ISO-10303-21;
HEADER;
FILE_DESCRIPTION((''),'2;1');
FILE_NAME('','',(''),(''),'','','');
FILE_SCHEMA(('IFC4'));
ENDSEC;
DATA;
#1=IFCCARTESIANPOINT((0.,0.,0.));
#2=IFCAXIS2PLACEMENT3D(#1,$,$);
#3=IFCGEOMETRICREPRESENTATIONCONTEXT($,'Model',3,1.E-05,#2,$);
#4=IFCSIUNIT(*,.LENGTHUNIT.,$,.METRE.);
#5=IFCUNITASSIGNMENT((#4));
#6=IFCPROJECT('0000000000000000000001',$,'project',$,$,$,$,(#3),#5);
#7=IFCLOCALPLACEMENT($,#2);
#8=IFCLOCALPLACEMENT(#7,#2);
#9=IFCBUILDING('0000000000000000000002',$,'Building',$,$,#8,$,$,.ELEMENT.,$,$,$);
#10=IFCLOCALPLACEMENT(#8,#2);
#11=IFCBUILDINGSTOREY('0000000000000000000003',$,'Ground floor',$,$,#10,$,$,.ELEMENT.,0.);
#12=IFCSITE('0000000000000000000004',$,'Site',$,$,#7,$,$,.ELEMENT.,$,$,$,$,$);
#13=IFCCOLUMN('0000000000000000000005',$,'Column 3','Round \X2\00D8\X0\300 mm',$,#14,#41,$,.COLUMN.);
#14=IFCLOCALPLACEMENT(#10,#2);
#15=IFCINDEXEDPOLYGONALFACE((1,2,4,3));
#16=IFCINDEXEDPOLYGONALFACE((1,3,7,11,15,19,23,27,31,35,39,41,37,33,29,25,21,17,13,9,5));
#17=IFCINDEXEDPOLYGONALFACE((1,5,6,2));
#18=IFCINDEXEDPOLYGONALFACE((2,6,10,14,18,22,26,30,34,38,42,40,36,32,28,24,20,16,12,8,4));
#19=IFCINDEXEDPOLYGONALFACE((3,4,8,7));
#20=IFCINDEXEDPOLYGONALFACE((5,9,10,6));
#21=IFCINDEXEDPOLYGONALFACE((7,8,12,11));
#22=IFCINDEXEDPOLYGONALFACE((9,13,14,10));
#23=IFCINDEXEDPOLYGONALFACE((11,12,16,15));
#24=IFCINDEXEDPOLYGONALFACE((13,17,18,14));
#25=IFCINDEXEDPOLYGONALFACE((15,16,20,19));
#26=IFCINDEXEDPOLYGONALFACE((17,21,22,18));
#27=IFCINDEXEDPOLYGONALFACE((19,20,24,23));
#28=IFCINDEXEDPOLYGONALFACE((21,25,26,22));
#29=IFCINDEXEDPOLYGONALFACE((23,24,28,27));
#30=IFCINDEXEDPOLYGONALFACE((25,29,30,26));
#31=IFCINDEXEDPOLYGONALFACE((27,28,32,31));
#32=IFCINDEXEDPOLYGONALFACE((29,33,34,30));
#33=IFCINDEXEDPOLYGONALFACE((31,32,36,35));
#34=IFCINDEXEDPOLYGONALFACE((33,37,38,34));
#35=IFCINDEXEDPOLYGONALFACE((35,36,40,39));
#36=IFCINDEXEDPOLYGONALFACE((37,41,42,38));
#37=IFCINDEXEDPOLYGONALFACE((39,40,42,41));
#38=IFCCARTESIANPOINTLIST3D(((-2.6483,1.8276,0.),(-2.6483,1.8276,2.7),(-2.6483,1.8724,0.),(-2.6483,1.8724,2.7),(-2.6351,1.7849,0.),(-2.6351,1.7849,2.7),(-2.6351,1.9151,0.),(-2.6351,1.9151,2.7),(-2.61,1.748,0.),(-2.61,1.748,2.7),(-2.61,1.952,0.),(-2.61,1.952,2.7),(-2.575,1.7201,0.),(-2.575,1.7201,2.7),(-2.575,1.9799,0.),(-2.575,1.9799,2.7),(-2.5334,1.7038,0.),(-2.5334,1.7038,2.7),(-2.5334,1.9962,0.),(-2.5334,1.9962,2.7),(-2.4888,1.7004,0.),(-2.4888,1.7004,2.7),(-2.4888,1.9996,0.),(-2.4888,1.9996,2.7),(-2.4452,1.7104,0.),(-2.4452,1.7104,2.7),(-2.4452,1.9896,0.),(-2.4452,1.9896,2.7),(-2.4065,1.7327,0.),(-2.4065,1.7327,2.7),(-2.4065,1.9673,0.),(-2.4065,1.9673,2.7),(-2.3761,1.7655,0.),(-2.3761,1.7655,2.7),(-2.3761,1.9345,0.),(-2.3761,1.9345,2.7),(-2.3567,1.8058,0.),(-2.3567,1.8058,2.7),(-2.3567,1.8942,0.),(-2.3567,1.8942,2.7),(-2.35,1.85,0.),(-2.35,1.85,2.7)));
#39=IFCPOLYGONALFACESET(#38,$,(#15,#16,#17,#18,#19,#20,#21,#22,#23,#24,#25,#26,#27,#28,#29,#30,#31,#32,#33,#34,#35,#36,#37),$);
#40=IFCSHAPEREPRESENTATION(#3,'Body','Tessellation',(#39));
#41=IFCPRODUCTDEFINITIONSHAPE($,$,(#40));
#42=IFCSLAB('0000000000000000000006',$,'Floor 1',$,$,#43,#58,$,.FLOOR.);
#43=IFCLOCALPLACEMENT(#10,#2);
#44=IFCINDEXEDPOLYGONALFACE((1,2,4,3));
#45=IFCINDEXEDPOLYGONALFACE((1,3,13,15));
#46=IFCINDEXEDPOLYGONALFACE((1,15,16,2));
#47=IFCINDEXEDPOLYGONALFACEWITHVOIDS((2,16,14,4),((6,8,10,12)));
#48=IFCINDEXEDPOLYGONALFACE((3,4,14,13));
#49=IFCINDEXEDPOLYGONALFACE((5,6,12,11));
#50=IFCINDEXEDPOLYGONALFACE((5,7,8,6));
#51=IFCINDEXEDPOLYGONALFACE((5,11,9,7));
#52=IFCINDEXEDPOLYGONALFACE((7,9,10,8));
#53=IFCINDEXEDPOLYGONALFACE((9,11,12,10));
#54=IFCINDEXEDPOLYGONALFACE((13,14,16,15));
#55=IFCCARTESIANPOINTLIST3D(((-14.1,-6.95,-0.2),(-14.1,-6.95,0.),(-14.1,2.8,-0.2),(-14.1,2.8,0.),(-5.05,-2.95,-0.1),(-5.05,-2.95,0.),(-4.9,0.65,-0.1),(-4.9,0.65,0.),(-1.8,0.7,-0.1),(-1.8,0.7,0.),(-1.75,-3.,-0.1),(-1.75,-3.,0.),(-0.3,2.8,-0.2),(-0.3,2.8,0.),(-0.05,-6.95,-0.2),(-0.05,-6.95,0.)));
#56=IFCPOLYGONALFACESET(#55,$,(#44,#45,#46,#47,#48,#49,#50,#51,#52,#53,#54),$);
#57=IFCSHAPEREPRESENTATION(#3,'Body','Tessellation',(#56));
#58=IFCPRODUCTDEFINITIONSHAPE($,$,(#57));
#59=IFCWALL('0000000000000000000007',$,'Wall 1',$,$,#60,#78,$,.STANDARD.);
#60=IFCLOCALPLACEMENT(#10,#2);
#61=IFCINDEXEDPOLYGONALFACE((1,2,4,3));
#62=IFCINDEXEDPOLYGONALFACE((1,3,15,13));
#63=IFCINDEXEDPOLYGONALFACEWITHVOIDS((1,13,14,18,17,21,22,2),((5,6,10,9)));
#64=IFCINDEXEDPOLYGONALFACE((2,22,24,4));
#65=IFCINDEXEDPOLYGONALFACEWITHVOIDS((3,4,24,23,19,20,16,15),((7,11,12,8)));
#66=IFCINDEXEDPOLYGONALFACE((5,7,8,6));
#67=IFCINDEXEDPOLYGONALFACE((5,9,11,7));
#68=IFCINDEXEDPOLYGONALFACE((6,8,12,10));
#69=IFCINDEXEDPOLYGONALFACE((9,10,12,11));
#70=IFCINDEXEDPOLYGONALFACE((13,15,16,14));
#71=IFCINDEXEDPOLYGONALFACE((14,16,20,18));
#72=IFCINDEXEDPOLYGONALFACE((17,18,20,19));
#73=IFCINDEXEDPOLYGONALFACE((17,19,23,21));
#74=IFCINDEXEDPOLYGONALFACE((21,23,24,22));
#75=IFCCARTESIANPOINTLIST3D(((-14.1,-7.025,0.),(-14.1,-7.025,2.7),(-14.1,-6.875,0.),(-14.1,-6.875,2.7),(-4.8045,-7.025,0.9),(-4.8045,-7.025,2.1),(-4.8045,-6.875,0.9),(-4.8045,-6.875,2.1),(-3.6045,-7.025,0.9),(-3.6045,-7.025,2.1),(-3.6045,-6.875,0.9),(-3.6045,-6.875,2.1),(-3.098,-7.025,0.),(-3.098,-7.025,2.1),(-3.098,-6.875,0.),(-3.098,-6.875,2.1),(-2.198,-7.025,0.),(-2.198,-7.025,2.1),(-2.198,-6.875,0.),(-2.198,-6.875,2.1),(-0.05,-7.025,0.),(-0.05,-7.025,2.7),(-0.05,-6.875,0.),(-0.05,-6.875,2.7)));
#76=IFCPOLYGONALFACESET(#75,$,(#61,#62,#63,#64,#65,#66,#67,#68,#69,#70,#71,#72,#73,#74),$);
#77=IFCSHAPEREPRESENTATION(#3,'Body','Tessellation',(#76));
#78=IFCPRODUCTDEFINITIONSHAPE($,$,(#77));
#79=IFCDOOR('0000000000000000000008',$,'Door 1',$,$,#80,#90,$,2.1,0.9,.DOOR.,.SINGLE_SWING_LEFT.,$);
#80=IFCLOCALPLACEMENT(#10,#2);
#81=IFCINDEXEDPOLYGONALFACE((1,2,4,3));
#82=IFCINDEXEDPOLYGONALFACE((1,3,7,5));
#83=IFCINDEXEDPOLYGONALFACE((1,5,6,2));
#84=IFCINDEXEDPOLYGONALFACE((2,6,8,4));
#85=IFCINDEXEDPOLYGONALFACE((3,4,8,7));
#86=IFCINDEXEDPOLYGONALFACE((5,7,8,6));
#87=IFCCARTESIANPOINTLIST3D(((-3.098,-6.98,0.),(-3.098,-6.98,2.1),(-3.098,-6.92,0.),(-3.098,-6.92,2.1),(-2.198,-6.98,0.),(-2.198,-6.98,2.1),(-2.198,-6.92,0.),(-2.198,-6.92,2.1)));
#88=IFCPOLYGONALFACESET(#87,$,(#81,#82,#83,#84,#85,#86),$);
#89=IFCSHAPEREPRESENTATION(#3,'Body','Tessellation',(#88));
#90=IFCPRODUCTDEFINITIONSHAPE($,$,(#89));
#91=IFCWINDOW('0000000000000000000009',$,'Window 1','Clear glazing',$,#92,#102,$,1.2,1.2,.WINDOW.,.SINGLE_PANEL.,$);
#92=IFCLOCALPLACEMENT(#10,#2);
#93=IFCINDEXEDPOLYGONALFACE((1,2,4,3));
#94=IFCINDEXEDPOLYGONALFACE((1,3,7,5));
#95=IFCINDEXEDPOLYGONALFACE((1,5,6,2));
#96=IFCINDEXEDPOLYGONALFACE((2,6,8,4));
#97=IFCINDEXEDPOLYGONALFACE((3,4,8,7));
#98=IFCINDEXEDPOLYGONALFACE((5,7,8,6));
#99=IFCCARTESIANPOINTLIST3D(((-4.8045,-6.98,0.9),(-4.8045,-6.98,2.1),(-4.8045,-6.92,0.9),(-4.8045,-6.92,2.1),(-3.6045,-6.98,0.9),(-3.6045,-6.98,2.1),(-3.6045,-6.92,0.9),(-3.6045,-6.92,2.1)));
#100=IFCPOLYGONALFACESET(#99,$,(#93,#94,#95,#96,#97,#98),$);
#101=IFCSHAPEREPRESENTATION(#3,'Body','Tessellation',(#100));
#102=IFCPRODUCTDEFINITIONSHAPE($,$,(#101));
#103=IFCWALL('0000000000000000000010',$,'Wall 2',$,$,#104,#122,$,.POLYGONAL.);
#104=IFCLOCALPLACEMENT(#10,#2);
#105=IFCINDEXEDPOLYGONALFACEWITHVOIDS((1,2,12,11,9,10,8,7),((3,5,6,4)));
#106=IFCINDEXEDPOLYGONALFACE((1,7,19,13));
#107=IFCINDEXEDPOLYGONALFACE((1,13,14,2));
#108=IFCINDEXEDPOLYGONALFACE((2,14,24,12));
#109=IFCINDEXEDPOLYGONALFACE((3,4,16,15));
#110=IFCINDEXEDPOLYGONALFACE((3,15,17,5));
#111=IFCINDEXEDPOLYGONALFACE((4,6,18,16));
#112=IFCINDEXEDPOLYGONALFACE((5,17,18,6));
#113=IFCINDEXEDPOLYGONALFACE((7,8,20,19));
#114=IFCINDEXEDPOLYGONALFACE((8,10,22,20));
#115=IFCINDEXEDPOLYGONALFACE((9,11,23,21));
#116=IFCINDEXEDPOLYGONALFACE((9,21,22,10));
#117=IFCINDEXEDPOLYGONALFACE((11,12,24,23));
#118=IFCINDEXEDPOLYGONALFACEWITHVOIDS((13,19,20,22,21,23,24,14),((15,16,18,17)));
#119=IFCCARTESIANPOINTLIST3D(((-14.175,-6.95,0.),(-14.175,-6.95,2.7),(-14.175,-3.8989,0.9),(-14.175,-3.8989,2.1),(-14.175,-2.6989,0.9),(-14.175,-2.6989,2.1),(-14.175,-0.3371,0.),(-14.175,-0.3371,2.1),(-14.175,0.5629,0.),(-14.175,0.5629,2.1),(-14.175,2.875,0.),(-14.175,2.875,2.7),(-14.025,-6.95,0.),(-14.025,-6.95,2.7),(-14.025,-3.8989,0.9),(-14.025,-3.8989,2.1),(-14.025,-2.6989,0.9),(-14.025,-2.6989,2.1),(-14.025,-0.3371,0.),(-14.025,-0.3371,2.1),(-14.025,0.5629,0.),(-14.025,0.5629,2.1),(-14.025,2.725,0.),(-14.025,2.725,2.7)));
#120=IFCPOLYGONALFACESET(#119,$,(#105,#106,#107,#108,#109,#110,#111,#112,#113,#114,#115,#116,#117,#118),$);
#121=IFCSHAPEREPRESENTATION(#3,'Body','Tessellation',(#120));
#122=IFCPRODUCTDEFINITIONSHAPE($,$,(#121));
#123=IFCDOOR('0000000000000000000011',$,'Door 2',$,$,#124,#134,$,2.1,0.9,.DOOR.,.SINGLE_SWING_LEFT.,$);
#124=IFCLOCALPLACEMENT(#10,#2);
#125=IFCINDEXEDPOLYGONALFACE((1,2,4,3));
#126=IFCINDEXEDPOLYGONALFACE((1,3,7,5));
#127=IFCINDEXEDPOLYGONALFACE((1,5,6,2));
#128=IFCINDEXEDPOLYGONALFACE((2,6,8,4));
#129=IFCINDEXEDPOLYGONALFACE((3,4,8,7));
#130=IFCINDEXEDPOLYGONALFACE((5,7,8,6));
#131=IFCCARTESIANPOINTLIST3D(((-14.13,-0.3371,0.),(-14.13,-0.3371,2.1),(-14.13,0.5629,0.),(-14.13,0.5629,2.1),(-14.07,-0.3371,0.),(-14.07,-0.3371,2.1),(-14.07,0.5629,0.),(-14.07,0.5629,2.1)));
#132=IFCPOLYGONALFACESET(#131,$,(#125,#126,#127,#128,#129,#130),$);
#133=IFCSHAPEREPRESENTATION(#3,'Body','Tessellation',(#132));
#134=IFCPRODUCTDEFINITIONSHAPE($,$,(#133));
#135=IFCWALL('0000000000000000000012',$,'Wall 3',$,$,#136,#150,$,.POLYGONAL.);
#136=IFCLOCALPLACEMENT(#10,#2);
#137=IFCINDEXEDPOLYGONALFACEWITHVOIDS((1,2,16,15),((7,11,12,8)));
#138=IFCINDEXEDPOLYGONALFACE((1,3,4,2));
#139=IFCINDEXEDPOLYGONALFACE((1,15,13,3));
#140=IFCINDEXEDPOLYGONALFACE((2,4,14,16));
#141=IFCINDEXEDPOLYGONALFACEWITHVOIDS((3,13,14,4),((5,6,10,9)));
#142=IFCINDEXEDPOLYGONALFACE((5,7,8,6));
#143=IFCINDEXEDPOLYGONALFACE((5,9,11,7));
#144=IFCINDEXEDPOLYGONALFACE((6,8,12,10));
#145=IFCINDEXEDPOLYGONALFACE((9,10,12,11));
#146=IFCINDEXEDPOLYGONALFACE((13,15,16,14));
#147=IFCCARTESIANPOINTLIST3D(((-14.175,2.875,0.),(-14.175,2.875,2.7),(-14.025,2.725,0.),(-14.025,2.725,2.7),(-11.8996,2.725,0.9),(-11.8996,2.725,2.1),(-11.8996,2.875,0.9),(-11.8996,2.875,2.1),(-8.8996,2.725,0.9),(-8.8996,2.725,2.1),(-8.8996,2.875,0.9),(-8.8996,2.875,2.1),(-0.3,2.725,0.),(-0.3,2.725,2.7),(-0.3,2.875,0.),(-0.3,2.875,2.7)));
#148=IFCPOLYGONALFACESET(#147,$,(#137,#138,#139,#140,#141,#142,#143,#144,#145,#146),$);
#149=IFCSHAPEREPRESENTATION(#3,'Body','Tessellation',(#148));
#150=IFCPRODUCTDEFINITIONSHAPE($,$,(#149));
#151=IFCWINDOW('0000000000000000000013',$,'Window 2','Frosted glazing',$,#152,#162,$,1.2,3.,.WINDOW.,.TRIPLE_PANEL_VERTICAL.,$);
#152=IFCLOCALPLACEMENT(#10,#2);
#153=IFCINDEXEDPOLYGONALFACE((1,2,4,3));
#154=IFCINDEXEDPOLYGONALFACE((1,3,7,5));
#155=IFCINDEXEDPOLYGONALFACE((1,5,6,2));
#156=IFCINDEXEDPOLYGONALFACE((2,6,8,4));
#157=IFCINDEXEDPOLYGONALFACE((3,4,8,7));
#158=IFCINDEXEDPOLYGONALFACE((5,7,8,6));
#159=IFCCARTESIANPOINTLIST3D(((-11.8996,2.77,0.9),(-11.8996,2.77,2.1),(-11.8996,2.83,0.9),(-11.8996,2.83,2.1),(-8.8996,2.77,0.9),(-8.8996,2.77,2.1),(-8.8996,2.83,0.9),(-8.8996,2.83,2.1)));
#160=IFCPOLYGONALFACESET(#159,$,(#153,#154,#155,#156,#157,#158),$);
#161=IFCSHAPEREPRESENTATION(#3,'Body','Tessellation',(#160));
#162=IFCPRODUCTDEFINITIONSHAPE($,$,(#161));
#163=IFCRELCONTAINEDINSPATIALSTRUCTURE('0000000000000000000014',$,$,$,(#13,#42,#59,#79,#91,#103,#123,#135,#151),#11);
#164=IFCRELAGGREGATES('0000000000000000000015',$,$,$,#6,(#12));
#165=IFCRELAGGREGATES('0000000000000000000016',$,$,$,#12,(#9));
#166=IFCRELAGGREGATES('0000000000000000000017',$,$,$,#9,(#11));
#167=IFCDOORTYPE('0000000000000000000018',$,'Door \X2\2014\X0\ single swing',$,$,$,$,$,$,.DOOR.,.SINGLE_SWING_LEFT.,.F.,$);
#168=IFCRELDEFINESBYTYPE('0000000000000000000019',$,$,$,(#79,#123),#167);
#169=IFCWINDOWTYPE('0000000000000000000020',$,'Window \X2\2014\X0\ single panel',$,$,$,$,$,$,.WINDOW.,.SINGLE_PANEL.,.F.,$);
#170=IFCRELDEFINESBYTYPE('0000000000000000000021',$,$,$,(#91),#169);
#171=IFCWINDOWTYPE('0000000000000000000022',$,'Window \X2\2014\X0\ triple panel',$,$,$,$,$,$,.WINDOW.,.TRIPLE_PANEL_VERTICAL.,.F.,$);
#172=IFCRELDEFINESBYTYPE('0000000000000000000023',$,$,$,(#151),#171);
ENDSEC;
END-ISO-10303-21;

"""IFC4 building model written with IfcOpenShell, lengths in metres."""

from ifc_helpers import new_model, si_unit, frame, frame_2d, origin, origin_with_axes, origin_2d, place, context, project, spatial, polyline, rectangle, circle, outline, extrude, type_object, element, fill, save


model = new_model("IFC4")

# Units and contexts
model_context = context("Model", 3, precision=1e-05, world=origin())
ifc_project = project(units=[si_unit("LENGTHUNIT", "METRE")], contexts=[model_context])

# Site, building, storey
site_placement = place(None, origin())
site = spatial("IfcSite", under=ifc_project, at=site_placement, Name="Site", CompositionType="ELEMENT")
building_placement = place(site_placement, origin())
building = spatial("IfcBuilding", under=site, at=building_placement, Name="Building", CompositionType="ELEMENT")
storey_placement = place(building_placement, origin())
storey = spatial("IfcBuildingStorey", under=building, at=storey_placement, Name="Ground floor", CompositionType="ELEMENT", Elevation=0.0)

# Column
column_placement = place(storey_placement, frame((-2.5, 1.85, 0.0), z_axis=(0.0, 0.0, 1.0), x_axis=(1.0, 0.0, 0.0)))
element("IfcColumn", 1, at=column_placement, inside=storey, Name="Column 3", Description="Round Ø300 mm", PredefinedType="COLUMN", context=model_context, shape_type="SweptSolid", body=[
    extrude(circle(Radius=0.15, at=origin_2d()), origin(), (0.0, 0.0, 1.0), 2.7),
])

# Slab, opening
slab_placement = place(storey_placement, frame((0.0, 0.0, -0.2), z_axis=(0.0, 0.0, 1.0), x_axis=(1.0, 0.0, 0.0)))
slab = element("IfcSlab", 2, at=slab_placement, inside=storey, Name="Floor 1", PredefinedType="FLOOR", context=model_context, shape_type="SweptSolid", body=[
    extrude(outline(polyline([(-14.1, 2.8), (-14.1, -6.95), (-0.05, -6.95), (-0.3, 2.8), (-14.1, 2.8)])), origin(), (0.0, 0.0, 1.0), 0.2),
])
opening_1_placement = place(storey_placement, frame((0.0, 0.0, -0.2), z_axis=(0.0, 0.0, 1.0), x_axis=(1.0, 0.0, 0.0)))
element("IfcOpeningElement", 3, at=opening_1_placement, cuts=slab, PredefinedType="RECESS", context=model_context, shape_type="SweptSolid", body=[
    extrude(outline(polyline([(-4.9, 0.65), (-5.05, -2.95), (-1.75, -3.0), (-1.8, 0.7), (-4.9, 0.65)])), frame((0.0, 0.0, 0.1)), (0.0, 0.0, 1.0), 0.12),
])

# Wall, openings, door, window
wall_1_placement = place(storey_placement, frame((-0.05, -6.95, 0.0), z_axis=(0.0, 0.0, 1.0), x_axis=(-1.0, 0.0, 0.0)))
wall_1 = element("IfcWall", 4, at=wall_1_placement, inside=storey, Name="Wall 1", PredefinedType="STANDARD", context=model_context, shape_type="SweptSolid", body=[
    extrude(rectangle(XDim=14.05, YDim=0.15, at=frame_2d((7.025, 0.0))), origin(), (0.0, 0.0, 1.0), 2.7),
])
opening_2_placement = place(storey_placement, frame((-3.6045, -6.95, 0.9), z_axis=(0.0, 0.0, 1.0), x_axis=(-1.0, 0.0, 0.0)))
opening_2 = element("IfcOpeningElement", 5, at=opening_2_placement, cuts=wall_1, PredefinedType="OPENING", context=model_context, shape_type="SweptSolid", body=[
    extrude(rectangle(XDim=1.2, YDim=0.21, at=frame_2d((0.6, 0.0))), origin(), (0.0, 0.0, 1.0), 1.2),
])
opening_3_placement = place(storey_placement, frame((-2.198, -6.95, 0.0), z_axis=(0.0, 0.0, 1.0), x_axis=(-1.0, 0.0, 0.0)))
opening_3 = element("IfcOpeningElement", 6, at=opening_3_placement, cuts=wall_1, PredefinedType="OPENING", context=model_context, shape_type="SweptSolid", body=[
    extrude(rectangle(XDim=0.9, YDim=0.21, at=frame_2d((0.45, 0.0))), origin(), (0.0, 0.0, 1.0), 2.1),
])
door_type = type_object("IfcDoorType", Name="Door — single swing", OperationType="SINGLE_SWING_LEFT", ParameterTakesPrecedence=False, PredefinedType="DOOR")
door_1_placement = place(storey_placement, frame((-2.198, -6.95, 0.0), z_axis=(0.0, 0.0, 1.0), x_axis=(-1.0, 0.0, 0.0)))
door_1 = element("IfcDoor", 7, at=door_1_placement, inside=storey, type_object=door_type, Name="Door 1", OperationType="SINGLE_SWING_LEFT", OverallHeight=2.1, OverallWidth=0.9, PredefinedType="DOOR", context=model_context, shape_type="SweptSolid", body=[
    extrude(rectangle(XDim=0.9, YDim=0.06, at=frame_2d((0.45, 0.0))), origin(), (0.0, 0.0, 1.0), 2.1),
])
fill(opening_3, door_1)
window_type_1 = type_object("IfcWindowType", Name="Window — single panel", ParameterTakesPrecedence=False, PartitioningType="SINGLE_PANEL", PredefinedType="WINDOW")
window_1_placement = place(storey_placement, frame((-3.6045, -6.95, 0.9), z_axis=(0.0, 0.0, 1.0), x_axis=(-1.0, 0.0, 0.0)))
window_1 = element("IfcWindow", 8, at=window_1_placement, inside=storey, type_object=window_type_1, Name="Window 1", Description="Clear glazing", OverallHeight=1.2, OverallWidth=1.2, PartitioningType="SINGLE_PANEL", PredefinedType="WINDOW", context=model_context, shape_type="SweptSolid", body=[
    extrude(rectangle(XDim=1.2, YDim=0.06, at=frame_2d((0.6, 0.0))), origin(), (0.0, 0.0, 1.0), 1.2),
])
fill(opening_2, window_1)

# Wall, openings, door
wall_2_placement = place(storey_placement, origin_with_axes())
wall_2 = element("IfcWall", 9, at=wall_2_placement, inside=storey, Name="Wall 2", PredefinedType="POLYGONAL", context=model_context, shape_type="SweptSolid", body=[
    extrude(outline(polyline([(-14.175, -6.95), (-14.025, -6.95), (-14.025, 2.725), (-14.175, 2.875), (-14.175, -6.95)])), origin(), (0.0, 0.0, 1.0), 2.7),
])
opening_4_placement = place(storey_placement, frame((-14.1, -3.8989, 0.9), z_axis=(0.0, 0.0, 1.0), x_axis=(0.0, 1.0, 0.0)))
element("IfcOpeningElement", 10, at=opening_4_placement, cuts=wall_2, PredefinedType="OPENING", context=model_context, shape_type="SweptSolid", body=[
    extrude(rectangle(XDim=1.2, YDim=0.21, at=frame_2d((0.6, 0.0))), origin(), (0.0, 0.0, 1.0), 1.2),
])
opening_5_placement = place(storey_placement, frame((-14.1, -0.3371, 0.0), z_axis=(0.0, 0.0, 1.0), x_axis=(0.0, 1.0, 0.0)))
opening_5 = element("IfcOpeningElement", 11, at=opening_5_placement, cuts=wall_2, PredefinedType="OPENING", context=model_context, shape_type="SweptSolid", body=[
    extrude(rectangle(XDim=0.9, YDim=0.21, at=frame_2d((0.45, 0.0))), origin(), (0.0, 0.0, 1.0), 2.1),
])
door_2_placement = place(storey_placement, frame((-14.1, -0.3371, 0.0), z_axis=(0.0, 0.0, 1.0), x_axis=(0.0, 1.0, 0.0)))
door_2 = element("IfcDoor", 12, at=door_2_placement, inside=storey, type_object=door_type, Name="Door 2", OperationType="SINGLE_SWING_LEFT", OverallHeight=2.1, OverallWidth=0.9, PredefinedType="DOOR", context=model_context, shape_type="SweptSolid", body=[
    extrude(rectangle(XDim=0.9, YDim=0.06, at=frame_2d((0.45, 0.0))), origin(), (0.0, 0.0, 1.0), 2.1),
])
fill(opening_5, door_2)

# Wall, opening, window
wall_3_placement = place(storey_placement, origin_with_axes())
wall_3 = element("IfcWall", 13, at=wall_3_placement, inside=storey, Name="Wall 3", PredefinedType="POLYGONAL", context=model_context, shape_type="SweptSolid", body=[
    extrude(outline(polyline([(-14.175, 2.875), (-14.025, 2.725), (-0.3, 2.725), (-0.3, 2.875), (-14.175, 2.875)])), origin(), (0.0, 0.0, 1.0), 2.7),
])
opening_6_placement = place(storey_placement, frame((-11.8996, 2.8, 0.9), z_axis=(0.0, 0.0, 1.0), x_axis=(1.0, 0.0, 0.0)))
opening_6 = element("IfcOpeningElement", 14, at=opening_6_placement, cuts=wall_3, PredefinedType="OPENING", context=model_context, shape_type="SweptSolid", body=[
    extrude(rectangle(XDim=3.0, YDim=0.21, at=frame_2d((1.5, 0.0))), origin(), (0.0, 0.0, 1.0), 1.2),
])
window_type_2 = type_object("IfcWindowType", Name="Window — triple panel", ParameterTakesPrecedence=False, PartitioningType="TRIPLE_PANEL_VERTICAL", PredefinedType="WINDOW")
window_2_placement = place(storey_placement, frame((-11.8996, 2.8, 0.9), z_axis=(0.0, 0.0, 1.0), x_axis=(1.0, 0.0, 0.0)))
window_2 = element("IfcWindow", 15, at=window_2_placement, inside=storey, type_object=window_type_2, Name="Window 2", Description="Frosted glazing", OverallHeight=1.2, OverallWidth=3.0, PartitioningType="TRIPLE_PANEL_VERTICAL", PredefinedType="WINDOW", context=model_context, shape_type="SweptSolid", body=[
    extrude(rectangle(XDim=3.0, YDim=0.06, at=frame_2d((1.5, 0.0))), origin(), (0.0, 0.0, 1.0), 1.2),
])
fill(opening_6, window_2)

save(model, "model.ifc")
